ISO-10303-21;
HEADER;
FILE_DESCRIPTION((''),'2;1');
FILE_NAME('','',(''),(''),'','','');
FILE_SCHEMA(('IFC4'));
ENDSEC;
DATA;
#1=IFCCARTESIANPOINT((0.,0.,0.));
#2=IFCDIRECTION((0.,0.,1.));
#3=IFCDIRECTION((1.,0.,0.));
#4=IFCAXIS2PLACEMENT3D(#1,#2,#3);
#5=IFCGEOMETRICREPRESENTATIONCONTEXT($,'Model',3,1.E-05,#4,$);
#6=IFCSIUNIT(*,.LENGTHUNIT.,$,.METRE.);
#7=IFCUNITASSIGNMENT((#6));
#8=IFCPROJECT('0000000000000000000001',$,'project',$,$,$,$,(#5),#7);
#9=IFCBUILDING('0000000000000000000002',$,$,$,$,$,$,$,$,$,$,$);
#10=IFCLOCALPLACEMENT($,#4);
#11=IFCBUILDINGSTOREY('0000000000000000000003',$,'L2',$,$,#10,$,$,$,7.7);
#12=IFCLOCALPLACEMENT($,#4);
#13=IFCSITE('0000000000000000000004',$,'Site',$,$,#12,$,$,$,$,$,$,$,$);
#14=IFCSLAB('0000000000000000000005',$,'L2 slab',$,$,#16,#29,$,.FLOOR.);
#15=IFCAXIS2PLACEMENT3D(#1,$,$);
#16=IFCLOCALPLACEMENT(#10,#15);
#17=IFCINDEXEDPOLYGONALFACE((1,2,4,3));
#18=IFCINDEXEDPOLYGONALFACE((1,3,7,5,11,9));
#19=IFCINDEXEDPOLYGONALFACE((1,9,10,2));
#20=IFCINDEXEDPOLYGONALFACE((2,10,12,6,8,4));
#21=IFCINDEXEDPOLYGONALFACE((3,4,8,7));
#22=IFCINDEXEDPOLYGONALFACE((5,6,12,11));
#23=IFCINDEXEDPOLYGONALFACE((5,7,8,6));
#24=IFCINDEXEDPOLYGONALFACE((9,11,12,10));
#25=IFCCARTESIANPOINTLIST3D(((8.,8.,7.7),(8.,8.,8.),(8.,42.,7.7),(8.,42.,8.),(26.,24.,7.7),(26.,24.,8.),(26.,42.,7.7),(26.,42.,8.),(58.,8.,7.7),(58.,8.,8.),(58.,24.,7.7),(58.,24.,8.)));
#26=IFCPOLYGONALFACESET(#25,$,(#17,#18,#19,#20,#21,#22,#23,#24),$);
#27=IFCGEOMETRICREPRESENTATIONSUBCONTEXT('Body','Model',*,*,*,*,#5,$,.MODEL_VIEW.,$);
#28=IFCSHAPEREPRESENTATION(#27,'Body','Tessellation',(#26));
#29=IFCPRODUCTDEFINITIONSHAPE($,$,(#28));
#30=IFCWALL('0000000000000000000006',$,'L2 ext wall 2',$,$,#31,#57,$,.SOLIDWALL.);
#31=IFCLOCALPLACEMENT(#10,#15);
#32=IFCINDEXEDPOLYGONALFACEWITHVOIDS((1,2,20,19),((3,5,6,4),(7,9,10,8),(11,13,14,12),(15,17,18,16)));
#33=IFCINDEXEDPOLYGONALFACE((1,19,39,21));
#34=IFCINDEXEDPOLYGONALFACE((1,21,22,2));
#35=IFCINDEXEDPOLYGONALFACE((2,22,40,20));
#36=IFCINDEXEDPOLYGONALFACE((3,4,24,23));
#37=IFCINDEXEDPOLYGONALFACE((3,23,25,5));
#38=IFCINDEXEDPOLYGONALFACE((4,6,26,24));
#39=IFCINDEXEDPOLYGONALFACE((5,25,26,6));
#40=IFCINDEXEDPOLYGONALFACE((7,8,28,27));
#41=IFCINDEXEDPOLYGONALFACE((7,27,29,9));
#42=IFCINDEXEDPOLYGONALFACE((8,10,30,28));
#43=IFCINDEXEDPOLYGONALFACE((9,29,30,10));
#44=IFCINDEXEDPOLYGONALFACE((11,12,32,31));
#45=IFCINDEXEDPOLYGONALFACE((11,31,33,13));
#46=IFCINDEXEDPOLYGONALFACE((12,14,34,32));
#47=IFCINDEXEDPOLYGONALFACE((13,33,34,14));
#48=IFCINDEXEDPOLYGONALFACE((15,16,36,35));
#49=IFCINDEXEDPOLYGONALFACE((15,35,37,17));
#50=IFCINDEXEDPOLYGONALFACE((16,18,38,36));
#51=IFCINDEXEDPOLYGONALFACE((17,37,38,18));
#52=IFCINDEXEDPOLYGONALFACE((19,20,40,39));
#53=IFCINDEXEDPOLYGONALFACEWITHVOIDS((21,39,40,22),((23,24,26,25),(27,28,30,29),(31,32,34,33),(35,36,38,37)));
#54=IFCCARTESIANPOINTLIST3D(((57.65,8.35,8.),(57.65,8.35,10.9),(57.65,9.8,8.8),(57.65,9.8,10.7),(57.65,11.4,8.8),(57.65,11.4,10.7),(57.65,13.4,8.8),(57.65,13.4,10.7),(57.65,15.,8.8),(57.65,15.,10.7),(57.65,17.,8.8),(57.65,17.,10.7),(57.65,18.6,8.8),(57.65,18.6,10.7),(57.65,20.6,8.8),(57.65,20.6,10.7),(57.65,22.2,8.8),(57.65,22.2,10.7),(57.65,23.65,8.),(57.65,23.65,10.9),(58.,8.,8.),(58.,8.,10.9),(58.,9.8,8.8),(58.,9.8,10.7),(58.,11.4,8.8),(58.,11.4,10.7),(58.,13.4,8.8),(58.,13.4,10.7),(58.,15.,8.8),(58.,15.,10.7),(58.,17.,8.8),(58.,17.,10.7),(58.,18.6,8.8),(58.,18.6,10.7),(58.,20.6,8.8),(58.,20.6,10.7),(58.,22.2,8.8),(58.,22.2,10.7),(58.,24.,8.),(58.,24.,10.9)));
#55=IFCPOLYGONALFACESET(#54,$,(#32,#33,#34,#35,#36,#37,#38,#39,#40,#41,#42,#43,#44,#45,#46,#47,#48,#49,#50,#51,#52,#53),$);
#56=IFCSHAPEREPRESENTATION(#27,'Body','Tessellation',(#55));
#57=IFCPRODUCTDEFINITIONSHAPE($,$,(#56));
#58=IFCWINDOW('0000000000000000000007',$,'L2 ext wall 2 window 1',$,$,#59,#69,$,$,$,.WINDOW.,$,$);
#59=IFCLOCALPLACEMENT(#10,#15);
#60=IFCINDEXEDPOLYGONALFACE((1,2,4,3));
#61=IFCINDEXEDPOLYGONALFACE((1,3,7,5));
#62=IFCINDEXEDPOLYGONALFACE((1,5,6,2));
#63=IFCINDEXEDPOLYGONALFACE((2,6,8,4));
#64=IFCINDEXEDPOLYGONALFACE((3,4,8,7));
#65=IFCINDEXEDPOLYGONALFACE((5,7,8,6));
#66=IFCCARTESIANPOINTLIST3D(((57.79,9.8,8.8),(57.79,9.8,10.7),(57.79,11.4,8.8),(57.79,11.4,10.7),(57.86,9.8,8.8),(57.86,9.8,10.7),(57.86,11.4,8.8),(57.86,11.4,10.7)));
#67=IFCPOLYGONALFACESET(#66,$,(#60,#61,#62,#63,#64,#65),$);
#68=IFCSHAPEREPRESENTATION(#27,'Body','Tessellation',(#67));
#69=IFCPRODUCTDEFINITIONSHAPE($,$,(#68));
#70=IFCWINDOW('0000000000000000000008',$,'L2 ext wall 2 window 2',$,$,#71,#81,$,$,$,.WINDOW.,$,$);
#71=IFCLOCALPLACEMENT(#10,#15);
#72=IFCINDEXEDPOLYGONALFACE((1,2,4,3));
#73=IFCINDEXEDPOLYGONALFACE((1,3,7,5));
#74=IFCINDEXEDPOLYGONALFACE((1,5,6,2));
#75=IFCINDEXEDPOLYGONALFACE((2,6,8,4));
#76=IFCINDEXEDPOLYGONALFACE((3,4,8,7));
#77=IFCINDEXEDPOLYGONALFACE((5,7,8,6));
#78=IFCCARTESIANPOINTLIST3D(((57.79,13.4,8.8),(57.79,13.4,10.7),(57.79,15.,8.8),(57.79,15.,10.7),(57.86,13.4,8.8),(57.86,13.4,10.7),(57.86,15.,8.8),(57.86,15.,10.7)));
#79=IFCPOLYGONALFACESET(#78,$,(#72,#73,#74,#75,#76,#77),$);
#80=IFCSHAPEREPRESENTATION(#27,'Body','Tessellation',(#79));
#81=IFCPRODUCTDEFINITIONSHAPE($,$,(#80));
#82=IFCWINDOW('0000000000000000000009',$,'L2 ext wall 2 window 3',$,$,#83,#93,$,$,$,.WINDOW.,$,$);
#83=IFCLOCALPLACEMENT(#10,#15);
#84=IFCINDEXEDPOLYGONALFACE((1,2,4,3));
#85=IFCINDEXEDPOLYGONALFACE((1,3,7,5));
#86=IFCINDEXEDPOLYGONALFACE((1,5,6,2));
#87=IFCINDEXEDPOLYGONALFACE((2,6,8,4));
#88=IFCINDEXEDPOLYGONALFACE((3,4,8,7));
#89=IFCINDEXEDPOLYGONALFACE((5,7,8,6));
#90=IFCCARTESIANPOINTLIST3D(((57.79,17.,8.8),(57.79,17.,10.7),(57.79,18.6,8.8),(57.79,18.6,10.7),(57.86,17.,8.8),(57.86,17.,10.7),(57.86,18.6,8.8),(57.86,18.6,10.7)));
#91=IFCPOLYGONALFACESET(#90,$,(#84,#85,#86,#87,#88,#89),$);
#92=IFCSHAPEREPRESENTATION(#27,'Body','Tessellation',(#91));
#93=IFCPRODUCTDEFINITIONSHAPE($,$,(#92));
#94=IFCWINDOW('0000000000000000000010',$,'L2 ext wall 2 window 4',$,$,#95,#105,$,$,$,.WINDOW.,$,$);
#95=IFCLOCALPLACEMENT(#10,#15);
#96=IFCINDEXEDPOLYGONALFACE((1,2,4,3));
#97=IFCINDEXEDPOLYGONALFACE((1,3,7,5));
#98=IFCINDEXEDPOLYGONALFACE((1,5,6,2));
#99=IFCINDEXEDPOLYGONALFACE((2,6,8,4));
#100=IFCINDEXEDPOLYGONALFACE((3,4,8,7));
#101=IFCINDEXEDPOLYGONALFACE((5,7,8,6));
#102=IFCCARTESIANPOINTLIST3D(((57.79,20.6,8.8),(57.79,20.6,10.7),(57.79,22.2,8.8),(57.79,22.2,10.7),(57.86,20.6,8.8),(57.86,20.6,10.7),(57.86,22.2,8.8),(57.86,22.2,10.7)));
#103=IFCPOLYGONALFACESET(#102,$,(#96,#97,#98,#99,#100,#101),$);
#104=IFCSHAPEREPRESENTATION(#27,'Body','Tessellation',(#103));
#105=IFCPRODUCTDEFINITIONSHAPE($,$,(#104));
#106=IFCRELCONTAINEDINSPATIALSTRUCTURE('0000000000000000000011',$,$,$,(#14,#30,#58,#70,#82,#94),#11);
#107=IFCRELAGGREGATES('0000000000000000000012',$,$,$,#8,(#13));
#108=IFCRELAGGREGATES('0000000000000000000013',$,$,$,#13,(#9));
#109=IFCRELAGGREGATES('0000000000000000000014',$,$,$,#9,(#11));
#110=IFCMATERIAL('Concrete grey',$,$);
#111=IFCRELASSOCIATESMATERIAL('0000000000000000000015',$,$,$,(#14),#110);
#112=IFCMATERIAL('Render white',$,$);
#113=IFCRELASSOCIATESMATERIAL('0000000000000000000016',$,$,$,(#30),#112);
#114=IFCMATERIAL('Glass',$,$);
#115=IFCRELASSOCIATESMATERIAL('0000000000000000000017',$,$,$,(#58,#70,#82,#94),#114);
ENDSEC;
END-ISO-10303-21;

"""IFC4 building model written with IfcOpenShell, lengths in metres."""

from ifc_helpers import new_model, si_unit, frame, origin_with_axes, place, context, subcontext, project, spatial, polyline, outline, extrude, material, element, fill, save


model = new_model("IFC4")

# Units and contexts
model_context = context("Model", 3, precision=1e-05, world=origin_with_axes())
body_context = subcontext(model_context, "Body", "Model", "MODEL_VIEW")
ifc_project = project(units=[si_unit("LENGTHUNIT", "METRE")], contexts=[model_context])

# Site, building, storey
site_placement = place(None, origin_with_axes())
site = spatial("IfcSite", under=ifc_project, at=site_placement, Name="Site")
building = spatial("IfcBuilding", under=site)
storey_placement = place(None, origin_with_axes())
storey = spatial("IfcBuildingStorey", under=building, at=storey_placement, Name="L2", Elevation=7.7)

# Slab
ifc_material_1 = material(Name="Concrete grey")
slab_placement = place(storey_placement, origin_with_axes())
element("IfcSlab", 1, at=slab_placement, inside=storey, material=ifc_material_1, Name="L2 slab", PredefinedType="FLOOR", context=body_context, shape_type="SweptSolid", body=[
    extrude(outline(polyline([(8.0, 8.0), (58.0, 8.0), (58.0, 24.0), (26.0, 24.0), (26.0, 42.0), (8.0, 42.0), (8.0, 8.0)])), frame((0.0, 0.0, 7.7), z_axis=(0.0, 0.0, 1.0), x_axis=(1.0, 0.0, 0.0)), (0.0, 0.0, 1.0), 0.3),
])

# Wall, openings, windows
ifc_material_2 = material(Name="Render white")
ifc_material_3 = material(Name="Glass")
wall_1_placement = place(storey_placement, origin_with_axes())
wall_1 = element("IfcWall", 2, at=wall_1_placement, inside=storey, material=ifc_material_2, Name="L2 ext wall 2", PredefinedType="SOLIDWALL", context=body_context, shape_type="SweptSolid", body=[
    extrude(outline(polyline([(58.0, 8.0), (58.0, 24.0), (57.65, 23.65), (57.65, 8.35), (58.0, 8.0)])), frame((0.0, 0.0, 8.0), z_axis=(0.0, 0.0, 1.0), x_axis=(1.0, 0.0, 0.0)), (0.0, 0.0, 1.0), 2.9),
])
opening_1_placement = place(wall_1_placement, origin_with_axes())
opening_1 = element("IfcOpeningElement", 3, at=opening_1_placement, cuts=wall_1, context=body_context, shape_type="SweptSolid", body=[
    extrude(outline(polyline([(58.05, 9.8), (58.05, 11.4), (57.6, 11.4), (57.6, 9.8), (58.05, 9.8)])), frame((0.0, 0.0, 8.8), z_axis=(0.0, 0.0, 1.0), x_axis=(1.0, 0.0, 0.0)), (0.0, 0.0, 1.0), 1.9),
])
opening_2_placement = place(wall_1_placement, origin_with_axes())
opening_2 = element("IfcOpeningElement", 4, at=opening_2_placement, cuts=wall_1, context=body_context, shape_type="SweptSolid", body=[
    extrude(outline(polyline([(58.05, 13.4), (58.05, 15.0), (57.6, 15.0), (57.6, 13.4), (58.05, 13.4)])), frame((0.0, 0.0, 8.8), z_axis=(0.0, 0.0, 1.0), x_axis=(1.0, 0.0, 0.0)), (0.0, 0.0, 1.0), 1.9),
])
opening_3_placement = place(wall_1_placement, origin_with_axes())
opening_3 = element("IfcOpeningElement", 5, at=opening_3_placement, cuts=wall_1, context=body_context, shape_type="SweptSolid", body=[
    extrude(outline(polyline([(58.05, 17.0), (58.05, 18.6), (57.6, 18.6), (57.6, 17.0), (58.05, 17.0)])), frame((0.0, 0.0, 8.8), z_axis=(0.0, 0.0, 1.0), x_axis=(1.0, 0.0, 0.0)), (0.0, 0.0, 1.0), 1.9),
])
opening_4_placement = place(wall_1_placement, origin_with_axes())
opening_4 = element("IfcOpeningElement", 6, at=opening_4_placement, cuts=wall_1, context=body_context, shape_type="SweptSolid", body=[
    extrude(outline(polyline([(58.05, 20.6), (58.05, 22.2), (57.6, 22.2), (57.6, 20.6), (58.05, 20.6)])), frame((0.0, 0.0, 8.8), z_axis=(0.0, 0.0, 1.0), x_axis=(1.0, 0.0, 0.0)), (0.0, 0.0, 1.0), 1.9),
])
window_1_placement = place(storey_placement, origin_with_axes())
window_1 = element("IfcWindow", 7, at=window_1_placement, inside=storey, material=ifc_material_3, Name="L2 ext wall 2 window 1", PredefinedType="WINDOW", context=body_context, shape_type="SweptSolid", body=[
    extrude(outline(polyline([(57.86, 9.8), (57.86, 11.4), (57.79, 11.4), (57.79, 9.8), (57.86, 9.8)])), frame((0.0, 0.0, 8.8), z_axis=(0.0, 0.0, 1.0), x_axis=(1.0, 0.0, 0.0)), (0.0, 0.0, 1.0), 1.9),
])
fill(opening_1, window_1)
window_2_placement = place(storey_placement, origin_with_axes())
window_2 = element("IfcWindow", 8, at=window_2_placement, inside=storey, material=ifc_material_3, Name="L2 ext wall 2 window 2", PredefinedType="WINDOW", context=body_context, shape_type="SweptSolid", body=[
    extrude(outline(polyline([(57.86, 13.4), (57.86, 15.0), (57.79, 15.0), (57.79, 13.4), (57.86, 13.4)])), frame((0.0, 0.0, 8.8), z_axis=(0.0, 0.0, 1.0), x_axis=(1.0, 0.0, 0.0)), (0.0, 0.0, 1.0), 1.9),
])
fill(opening_2, window_2)
window_3_placement = place(storey_placement, origin_with_axes())
window_3 = element("IfcWindow", 9, at=window_3_placement, inside=storey, material=ifc_material_3, Name="L2 ext wall 2 window 3", PredefinedType="WINDOW", context=body_context, shape_type="SweptSolid", body=[
    extrude(outline(polyline([(57.86, 17.0), (57.86, 18.6), (57.79, 18.6), (57.79, 17.0), (57.86, 17.0)])), frame((0.0, 0.0, 8.8), z_axis=(0.0, 0.0, 1.0), x_axis=(1.0, 0.0, 0.0)), (0.0, 0.0, 1.0), 1.9),
])
fill(opening_3, window_3)
window_4_placement = place(storey_placement, origin_with_axes())
window_4 = element("IfcWindow", 10, at=window_4_placement, inside=storey, material=ifc_material_3, Name="L2 ext wall 2 window 4", PredefinedType="WINDOW", context=body_context, shape_type="SweptSolid", body=[
    extrude(outline(polyline([(57.86, 20.6), (57.86, 22.2), (57.79, 22.2), (57.79, 20.6), (57.86, 20.6)])), frame((0.0, 0.0, 8.8), z_axis=(0.0, 0.0, 1.0), x_axis=(1.0, 0.0, 0.0)), (0.0, 0.0, 1.0), 1.9),
])
fill(opening_4, window_4)

save(model, "model.ifc")
